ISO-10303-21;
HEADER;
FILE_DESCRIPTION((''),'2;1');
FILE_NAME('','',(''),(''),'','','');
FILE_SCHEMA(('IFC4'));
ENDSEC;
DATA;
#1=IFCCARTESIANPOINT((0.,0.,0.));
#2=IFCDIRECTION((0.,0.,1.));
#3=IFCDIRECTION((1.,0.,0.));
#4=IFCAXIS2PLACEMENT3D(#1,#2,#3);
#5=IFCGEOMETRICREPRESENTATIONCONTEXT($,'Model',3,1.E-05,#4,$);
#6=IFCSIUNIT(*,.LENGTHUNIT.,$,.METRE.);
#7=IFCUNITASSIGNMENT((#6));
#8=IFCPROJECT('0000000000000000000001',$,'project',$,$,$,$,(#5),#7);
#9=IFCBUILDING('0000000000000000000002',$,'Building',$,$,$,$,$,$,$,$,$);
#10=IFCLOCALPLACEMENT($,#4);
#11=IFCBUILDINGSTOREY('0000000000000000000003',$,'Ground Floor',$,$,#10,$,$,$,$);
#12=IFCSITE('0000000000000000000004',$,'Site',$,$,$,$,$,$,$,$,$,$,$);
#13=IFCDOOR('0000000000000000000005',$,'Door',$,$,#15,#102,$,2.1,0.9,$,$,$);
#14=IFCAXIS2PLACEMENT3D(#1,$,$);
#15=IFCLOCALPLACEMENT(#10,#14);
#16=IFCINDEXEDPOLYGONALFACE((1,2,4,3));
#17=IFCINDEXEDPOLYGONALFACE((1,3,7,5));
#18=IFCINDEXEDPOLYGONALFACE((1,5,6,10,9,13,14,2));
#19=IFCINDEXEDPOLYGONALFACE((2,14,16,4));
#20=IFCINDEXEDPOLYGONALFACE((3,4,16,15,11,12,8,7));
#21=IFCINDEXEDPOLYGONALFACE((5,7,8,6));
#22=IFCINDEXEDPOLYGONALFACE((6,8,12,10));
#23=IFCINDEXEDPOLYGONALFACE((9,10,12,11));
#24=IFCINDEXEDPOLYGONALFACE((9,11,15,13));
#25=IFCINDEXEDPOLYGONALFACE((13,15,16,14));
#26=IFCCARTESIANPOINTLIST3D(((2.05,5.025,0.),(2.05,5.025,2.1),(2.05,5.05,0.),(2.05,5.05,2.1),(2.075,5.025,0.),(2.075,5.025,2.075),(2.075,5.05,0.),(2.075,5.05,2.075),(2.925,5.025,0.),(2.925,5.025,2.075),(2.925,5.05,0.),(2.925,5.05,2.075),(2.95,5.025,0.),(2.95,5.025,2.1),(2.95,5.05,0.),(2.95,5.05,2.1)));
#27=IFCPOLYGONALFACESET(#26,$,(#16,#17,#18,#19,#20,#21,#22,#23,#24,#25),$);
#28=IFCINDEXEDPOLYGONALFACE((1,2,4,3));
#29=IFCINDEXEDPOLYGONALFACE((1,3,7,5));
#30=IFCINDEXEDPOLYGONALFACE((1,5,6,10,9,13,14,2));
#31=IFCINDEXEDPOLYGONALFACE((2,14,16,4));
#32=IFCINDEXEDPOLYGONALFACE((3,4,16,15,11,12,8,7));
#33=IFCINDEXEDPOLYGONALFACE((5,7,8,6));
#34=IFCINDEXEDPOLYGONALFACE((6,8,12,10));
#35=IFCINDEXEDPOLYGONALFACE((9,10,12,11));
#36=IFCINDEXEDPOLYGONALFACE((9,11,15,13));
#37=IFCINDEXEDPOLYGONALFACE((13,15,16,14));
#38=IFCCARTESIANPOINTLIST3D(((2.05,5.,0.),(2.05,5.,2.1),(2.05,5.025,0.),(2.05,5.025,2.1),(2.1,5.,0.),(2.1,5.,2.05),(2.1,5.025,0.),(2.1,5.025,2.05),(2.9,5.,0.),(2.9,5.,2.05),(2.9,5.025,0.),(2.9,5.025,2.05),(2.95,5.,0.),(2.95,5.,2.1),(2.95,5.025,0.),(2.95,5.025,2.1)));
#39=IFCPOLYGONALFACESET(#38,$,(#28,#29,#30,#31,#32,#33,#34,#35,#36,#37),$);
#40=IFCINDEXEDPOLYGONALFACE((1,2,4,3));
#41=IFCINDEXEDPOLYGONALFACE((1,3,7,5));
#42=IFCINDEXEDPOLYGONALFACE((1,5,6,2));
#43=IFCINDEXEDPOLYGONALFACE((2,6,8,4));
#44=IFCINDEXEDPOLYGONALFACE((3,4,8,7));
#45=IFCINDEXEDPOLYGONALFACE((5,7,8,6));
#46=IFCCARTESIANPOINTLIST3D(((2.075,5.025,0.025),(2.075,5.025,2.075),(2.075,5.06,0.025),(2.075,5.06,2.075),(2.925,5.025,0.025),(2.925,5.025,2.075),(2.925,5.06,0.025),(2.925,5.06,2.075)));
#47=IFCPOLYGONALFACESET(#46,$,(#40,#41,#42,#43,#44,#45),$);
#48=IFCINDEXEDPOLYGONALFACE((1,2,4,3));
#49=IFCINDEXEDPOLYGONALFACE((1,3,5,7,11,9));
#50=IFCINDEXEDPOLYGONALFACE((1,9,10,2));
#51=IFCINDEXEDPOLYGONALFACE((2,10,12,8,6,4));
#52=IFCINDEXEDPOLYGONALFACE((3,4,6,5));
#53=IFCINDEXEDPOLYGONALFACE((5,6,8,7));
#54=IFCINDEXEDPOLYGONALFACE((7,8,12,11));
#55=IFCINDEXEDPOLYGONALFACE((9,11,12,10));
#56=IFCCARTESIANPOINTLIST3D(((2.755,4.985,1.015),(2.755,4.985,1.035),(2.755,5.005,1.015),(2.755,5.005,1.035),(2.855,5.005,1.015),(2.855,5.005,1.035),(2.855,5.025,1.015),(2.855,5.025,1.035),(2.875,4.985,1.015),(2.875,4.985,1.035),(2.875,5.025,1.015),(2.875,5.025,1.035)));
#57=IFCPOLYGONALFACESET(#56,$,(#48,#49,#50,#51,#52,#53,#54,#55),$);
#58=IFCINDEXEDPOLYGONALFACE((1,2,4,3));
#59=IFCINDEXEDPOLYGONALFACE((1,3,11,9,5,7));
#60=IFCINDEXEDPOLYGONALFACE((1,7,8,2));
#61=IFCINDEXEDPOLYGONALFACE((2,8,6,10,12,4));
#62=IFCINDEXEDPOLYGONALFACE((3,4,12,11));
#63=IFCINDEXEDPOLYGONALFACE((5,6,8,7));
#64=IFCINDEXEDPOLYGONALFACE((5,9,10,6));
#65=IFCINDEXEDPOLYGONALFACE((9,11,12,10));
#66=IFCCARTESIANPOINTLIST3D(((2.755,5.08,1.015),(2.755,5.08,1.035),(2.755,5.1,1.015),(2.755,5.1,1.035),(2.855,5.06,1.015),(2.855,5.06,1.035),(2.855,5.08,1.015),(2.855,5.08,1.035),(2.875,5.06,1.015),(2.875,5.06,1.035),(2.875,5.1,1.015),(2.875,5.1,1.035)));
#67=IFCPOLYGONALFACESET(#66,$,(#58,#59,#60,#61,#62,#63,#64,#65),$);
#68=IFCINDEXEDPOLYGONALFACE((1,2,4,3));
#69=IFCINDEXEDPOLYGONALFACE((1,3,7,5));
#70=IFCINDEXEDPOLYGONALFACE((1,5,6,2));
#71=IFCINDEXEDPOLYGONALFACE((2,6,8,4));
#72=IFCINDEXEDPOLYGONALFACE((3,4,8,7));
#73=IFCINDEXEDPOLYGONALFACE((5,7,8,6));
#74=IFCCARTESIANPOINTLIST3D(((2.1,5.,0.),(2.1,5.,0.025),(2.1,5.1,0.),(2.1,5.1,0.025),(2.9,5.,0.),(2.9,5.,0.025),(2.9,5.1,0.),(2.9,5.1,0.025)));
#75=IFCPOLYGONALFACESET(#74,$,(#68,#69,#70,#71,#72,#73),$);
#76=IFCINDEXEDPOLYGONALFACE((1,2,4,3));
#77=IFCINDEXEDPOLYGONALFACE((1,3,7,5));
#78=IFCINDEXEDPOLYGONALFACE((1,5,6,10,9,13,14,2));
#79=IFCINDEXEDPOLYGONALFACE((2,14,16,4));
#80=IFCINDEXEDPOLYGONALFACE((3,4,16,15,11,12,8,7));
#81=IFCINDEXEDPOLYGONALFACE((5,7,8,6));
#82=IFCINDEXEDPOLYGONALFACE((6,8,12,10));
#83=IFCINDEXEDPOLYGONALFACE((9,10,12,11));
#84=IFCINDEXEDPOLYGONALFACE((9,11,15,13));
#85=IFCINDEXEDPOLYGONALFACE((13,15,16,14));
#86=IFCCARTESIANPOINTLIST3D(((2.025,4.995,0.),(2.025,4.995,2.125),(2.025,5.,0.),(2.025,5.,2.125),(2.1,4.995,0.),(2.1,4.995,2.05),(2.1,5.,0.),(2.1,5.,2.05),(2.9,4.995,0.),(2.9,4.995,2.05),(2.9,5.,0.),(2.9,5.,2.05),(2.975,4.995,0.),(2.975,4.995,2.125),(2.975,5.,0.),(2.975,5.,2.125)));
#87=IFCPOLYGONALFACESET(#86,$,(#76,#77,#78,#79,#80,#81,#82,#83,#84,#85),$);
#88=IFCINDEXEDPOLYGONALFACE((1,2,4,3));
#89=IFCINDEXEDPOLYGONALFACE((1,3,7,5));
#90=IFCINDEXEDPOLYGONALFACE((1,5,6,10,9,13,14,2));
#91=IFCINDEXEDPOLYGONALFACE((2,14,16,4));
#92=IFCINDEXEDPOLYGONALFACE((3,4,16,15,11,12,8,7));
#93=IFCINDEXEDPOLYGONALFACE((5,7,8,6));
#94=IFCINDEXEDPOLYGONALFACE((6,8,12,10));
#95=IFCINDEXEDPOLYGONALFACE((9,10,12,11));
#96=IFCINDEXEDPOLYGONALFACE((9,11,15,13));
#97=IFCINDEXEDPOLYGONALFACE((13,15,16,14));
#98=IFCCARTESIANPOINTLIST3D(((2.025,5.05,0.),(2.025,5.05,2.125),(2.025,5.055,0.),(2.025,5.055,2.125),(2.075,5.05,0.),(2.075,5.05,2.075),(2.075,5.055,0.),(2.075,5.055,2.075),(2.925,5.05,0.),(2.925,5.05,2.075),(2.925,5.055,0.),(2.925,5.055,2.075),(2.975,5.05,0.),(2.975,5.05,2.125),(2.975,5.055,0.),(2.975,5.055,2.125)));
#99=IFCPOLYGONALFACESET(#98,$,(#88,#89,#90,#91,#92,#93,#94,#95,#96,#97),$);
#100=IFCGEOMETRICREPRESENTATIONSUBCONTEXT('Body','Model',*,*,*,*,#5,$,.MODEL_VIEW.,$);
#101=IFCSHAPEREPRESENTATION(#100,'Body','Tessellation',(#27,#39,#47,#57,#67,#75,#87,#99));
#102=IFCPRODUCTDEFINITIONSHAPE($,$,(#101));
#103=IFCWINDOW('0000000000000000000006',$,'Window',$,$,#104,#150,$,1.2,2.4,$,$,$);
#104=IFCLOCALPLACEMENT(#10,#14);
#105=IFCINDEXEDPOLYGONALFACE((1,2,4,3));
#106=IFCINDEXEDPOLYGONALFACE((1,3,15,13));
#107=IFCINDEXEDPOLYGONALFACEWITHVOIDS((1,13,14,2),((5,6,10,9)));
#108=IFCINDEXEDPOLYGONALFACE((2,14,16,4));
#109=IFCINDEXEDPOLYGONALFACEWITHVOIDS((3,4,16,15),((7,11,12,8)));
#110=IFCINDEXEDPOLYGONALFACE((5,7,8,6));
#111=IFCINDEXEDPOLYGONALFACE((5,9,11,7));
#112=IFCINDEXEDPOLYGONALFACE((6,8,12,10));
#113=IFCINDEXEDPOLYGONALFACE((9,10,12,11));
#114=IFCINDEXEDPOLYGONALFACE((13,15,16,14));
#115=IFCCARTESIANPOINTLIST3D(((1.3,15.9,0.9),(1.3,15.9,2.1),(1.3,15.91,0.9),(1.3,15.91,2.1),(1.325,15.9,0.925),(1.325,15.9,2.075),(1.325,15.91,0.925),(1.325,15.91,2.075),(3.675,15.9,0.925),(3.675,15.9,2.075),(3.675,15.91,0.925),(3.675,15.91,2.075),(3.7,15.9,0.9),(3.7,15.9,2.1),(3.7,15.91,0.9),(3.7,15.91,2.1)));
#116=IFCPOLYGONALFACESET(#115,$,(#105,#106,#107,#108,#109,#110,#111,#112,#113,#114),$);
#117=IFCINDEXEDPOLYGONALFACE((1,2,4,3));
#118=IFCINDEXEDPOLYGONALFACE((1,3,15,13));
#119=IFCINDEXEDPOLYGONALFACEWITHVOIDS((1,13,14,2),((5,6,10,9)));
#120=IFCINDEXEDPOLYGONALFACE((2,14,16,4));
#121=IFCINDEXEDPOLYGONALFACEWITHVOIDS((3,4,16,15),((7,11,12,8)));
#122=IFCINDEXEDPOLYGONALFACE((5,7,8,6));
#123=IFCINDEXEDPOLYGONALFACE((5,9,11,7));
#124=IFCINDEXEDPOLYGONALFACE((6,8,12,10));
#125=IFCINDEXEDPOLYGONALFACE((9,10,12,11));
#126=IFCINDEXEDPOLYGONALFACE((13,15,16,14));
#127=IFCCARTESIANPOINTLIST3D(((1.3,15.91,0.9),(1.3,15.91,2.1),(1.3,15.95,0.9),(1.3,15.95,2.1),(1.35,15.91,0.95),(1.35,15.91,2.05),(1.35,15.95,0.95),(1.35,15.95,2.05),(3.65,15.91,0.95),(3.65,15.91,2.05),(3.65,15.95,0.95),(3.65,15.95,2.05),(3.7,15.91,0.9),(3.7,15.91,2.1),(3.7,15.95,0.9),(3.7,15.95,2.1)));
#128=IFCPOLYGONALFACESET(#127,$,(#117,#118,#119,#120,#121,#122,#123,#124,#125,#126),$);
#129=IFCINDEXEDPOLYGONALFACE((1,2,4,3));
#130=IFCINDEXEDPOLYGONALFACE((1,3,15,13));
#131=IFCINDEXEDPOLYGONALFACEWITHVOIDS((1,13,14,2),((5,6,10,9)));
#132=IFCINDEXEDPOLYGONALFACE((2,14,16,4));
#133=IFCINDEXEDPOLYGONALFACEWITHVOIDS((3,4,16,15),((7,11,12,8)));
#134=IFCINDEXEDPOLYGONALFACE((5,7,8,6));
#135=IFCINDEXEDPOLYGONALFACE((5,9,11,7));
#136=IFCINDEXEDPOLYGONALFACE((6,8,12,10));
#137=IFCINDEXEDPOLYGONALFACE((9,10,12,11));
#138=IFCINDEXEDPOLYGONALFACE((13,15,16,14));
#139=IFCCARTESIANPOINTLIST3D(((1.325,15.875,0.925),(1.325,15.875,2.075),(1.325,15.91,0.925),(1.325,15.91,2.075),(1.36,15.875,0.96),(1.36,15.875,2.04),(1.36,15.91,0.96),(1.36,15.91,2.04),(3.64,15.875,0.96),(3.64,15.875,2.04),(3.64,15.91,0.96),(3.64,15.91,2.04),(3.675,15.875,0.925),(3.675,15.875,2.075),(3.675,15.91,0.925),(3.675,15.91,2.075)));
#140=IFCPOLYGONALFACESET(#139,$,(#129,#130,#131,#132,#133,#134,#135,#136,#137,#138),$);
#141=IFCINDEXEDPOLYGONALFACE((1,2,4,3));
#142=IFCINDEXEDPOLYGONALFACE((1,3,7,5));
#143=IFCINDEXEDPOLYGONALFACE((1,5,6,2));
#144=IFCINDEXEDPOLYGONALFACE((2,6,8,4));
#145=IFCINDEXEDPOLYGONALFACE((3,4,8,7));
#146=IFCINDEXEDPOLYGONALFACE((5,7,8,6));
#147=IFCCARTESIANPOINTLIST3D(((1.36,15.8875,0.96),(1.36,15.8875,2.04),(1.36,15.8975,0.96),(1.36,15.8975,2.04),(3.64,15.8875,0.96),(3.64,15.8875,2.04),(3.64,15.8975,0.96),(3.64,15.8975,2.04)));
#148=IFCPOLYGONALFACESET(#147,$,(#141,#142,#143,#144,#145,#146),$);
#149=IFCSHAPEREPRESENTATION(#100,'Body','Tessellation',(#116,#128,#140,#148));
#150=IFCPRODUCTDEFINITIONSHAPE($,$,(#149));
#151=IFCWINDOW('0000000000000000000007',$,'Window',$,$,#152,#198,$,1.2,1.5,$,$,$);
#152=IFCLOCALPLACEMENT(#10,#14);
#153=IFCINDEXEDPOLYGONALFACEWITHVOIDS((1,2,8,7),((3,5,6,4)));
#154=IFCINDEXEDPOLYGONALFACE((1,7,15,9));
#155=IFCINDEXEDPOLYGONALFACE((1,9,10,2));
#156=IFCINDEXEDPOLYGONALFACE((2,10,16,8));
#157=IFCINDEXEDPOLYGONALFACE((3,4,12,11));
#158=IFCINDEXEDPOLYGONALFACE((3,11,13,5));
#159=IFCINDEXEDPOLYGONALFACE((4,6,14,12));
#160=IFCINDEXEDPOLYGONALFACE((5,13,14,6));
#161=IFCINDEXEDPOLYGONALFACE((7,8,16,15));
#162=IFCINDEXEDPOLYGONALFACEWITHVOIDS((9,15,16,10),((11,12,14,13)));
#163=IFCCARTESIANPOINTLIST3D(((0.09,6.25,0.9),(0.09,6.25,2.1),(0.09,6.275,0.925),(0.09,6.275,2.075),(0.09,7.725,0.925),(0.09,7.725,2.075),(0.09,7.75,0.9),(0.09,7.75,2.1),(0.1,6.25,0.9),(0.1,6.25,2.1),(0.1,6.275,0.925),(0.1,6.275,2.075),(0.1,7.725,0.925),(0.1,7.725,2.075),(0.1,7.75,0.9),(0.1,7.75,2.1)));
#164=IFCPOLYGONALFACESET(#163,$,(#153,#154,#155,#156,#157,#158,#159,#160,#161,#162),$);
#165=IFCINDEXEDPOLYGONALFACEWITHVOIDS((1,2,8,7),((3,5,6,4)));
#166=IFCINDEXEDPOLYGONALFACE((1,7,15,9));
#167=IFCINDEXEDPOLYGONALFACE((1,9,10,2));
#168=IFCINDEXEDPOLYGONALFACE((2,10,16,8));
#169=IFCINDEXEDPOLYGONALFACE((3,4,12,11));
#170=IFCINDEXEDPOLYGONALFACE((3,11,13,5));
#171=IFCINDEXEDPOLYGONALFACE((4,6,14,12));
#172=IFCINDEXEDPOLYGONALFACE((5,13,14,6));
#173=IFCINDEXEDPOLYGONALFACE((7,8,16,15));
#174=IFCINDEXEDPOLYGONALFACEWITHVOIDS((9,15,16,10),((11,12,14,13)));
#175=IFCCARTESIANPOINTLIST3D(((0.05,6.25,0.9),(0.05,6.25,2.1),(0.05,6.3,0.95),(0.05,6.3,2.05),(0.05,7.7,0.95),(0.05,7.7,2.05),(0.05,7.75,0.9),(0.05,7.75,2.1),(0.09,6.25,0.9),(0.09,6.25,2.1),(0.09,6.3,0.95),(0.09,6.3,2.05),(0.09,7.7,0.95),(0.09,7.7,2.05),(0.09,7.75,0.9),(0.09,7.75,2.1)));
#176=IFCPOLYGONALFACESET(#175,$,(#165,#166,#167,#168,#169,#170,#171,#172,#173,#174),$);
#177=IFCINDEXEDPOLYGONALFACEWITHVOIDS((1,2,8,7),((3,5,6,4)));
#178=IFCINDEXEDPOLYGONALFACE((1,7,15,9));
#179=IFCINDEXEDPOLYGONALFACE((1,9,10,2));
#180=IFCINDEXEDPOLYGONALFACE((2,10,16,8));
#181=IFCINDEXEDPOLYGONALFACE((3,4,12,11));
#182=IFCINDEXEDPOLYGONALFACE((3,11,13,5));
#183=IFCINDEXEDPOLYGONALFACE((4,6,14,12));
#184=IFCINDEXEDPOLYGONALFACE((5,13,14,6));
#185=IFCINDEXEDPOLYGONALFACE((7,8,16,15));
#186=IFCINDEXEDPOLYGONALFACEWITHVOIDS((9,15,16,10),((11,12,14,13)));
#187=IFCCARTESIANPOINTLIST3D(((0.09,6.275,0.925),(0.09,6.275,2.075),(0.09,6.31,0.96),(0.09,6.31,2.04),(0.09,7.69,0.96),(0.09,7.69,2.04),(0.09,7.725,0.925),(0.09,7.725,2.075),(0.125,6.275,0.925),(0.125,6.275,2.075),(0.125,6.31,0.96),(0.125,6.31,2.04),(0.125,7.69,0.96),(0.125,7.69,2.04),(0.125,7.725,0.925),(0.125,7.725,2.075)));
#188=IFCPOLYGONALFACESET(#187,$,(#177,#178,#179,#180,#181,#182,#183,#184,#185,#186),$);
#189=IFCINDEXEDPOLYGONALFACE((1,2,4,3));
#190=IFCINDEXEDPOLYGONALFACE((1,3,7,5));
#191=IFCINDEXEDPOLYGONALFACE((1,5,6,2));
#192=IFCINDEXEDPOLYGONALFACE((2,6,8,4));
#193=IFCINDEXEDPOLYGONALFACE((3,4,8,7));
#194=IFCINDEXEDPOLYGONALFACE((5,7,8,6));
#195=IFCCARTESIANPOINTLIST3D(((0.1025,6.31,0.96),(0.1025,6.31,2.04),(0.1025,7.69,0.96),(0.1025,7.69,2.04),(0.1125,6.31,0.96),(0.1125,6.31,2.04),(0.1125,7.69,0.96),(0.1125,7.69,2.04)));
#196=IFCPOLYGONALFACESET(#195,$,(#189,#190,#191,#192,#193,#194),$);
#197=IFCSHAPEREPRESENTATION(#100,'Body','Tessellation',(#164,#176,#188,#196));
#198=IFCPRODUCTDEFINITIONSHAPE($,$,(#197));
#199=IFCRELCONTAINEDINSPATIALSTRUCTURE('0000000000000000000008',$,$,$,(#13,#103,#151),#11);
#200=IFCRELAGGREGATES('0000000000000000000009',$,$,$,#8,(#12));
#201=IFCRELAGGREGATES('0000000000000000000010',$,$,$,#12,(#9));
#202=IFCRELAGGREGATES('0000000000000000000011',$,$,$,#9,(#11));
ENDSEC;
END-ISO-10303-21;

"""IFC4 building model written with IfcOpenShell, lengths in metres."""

from ifc_helpers import new_model, si_unit, frame, origin_with_axes, place, context, subcontext, project, spatial, line, indexed_curve, outline, extrude, element, save


model = new_model("IFC4")

# Units and contexts
model_context = context("Model", 3, precision=1e-05, world=origin_with_axes())
body_context = subcontext(model_context, "Body", "Model", "MODEL_VIEW")
ifc_project = project(units=[si_unit("LENGTHUNIT", "METRE")], contexts=[model_context])

# Site, building, storey
site = spatial("IfcSite", under=ifc_project, Name="Site")
building = spatial("IfcBuilding", under=site, Name="Building")
storey_placement = place(None, origin_with_axes())
storey = spatial("IfcBuildingStorey", under=building, at=storey_placement, Name="Ground Floor")

# Door
door_1_placement = place(storey_placement, frame((2.05, 5.0, 0.0), z_axis=(0.0, 0.0, 1.0), x_axis=(1.0, 0.0, 0.0)))
element("IfcDoor", 1, at=door_1_placement, inside=storey, Name="Door", OverallHeight=2.1, OverallWidth=0.9, context=body_context, shape_type="SweptSolid", body=[
    extrude(outline(indexed_curve([(0.0, 0.0), (0.0, 2.1), (0.9, 2.1), (0.9, 0.0), (0.875, 0.0), (0.875, 2.075), (0.025, 2.075), (0.025, 0.0)], segments=[line(1, 2, 3, 4, 5, 6, 7, 8, 1)])), frame((0.0, 0.025, 0.0), z_axis=(0.0, -1.0, 0.0), x_axis=(1.0, 0.0, 0.0)), (0.0, 0.0, -1.0), 0.025),
    extrude(outline(indexed_curve([(0.0, 0.0), (0.0, 2.1), (0.9, 2.1), (0.9, 0.0), (0.85, 0.0), (0.85, 2.05), (0.05, 2.05), (0.05, 0.0)], segments=[line(1, 2, 3, 4, 5, 6, 7, 8, 1)])), frame((0.0, 0.0, 0.0), z_axis=(0.0, -1.0, 0.0), x_axis=(1.0, 0.0, 0.0)), (0.0, 0.0, -1.0), 0.025),
    extrude(outline(indexed_curve([(0.0, 0.0), (0.85, 0.0), (0.85, 0.035), (0.0, 0.035)], segments=[line(1, 2, 3, 4, 1)])), frame((0.025, 0.025, 0.025), z_axis=(0.0, 0.0, 1.0), x_axis=(1.0, 0.0, 0.0)), (0.0, 0.0, 1.0), 2.05),
    extrude(outline(indexed_curve([(0.0, 0.0), (0.0, -0.04), (-0.12, -0.04), (-0.12, -0.02), (-0.02, -0.02), (-0.02, 0.0)], segments=[line(1, 2, 3, 4, 5, 6, 1)])), frame((0.825, 0.025, 1.015), z_axis=(0.0, 0.0, 1.0), x_axis=(1.0, 0.0, 0.0)), (0.0, 0.0, 1.0), 0.02),
    extrude(outline(indexed_curve([(0.0, 0.0), (0.0, 0.04), (-0.12, 0.04), (-0.12, 0.02), (-0.02, 0.02), (-0.02, 0.0)], segments=[line(1, 2, 3, 4, 5, 6, 1)])), frame((0.825, 0.06, 1.015), z_axis=(0.0, 0.0, 1.0), x_axis=(1.0, 0.0, 0.0)), (0.0, 0.0, 1.0), 0.02),
    extrude(outline(indexed_curve([(0.0, 0.0), (0.8, 0.0), (0.8, 0.1), (0.0, 0.1)], segments=[line(1, 2, 3, 4, 1)])), frame((0.05, 0.0, 0.0), z_axis=(0.0, 0.0, 1.0), x_axis=(1.0, 0.0, 0.0)), (0.0, 0.0, 1.0), 0.025),
    extrude(outline(indexed_curve([(0.0, 0.0), (0.0, 2.125), (0.95, 2.125), (0.95, 0.0), (0.875, 0.0), (0.875, 2.05), (0.075, 2.05), (0.075, 0.0)], segments=[line(1, 2, 3, 4, 5, 6, 7, 8, 1)])), frame((-0.025, -0.005, 0.0), z_axis=(0.0, -1.0, 0.0), x_axis=(1.0, 0.0, 0.0)), (0.0, 0.0, -1.0), 0.005),
    extrude(outline(indexed_curve([(0.0, 0.0), (0.0, 2.125), (0.95, 2.125), (0.95, 0.0), (0.9, 0.0), (0.9, 2.075), (0.05, 2.075), (0.05, 0.0)], segments=[line(1, 2, 3, 4, 5, 6, 7, 8, 1)])), frame((-0.025, 0.05, 0.0), z_axis=(0.0, -1.0, 0.0), x_axis=(1.0, 0.0, 0.0)), (0.0, 0.0, -1.0), 0.005),
])

# Windows
window_placement = place(storey_placement, frame((3.7, 16.0, 0.9), z_axis=(0.0, 0.0, 1.0), x_axis=(-1.0, 0.0, 0.0)))
element("IfcWindow", 2, at=window_placement, inside=storey, Name="Window", OverallHeight=1.2, OverallWidth=2.4, context=body_context, shape_type="SweptSolid", body=[
    extrude(outline(indexed_curve([(0.0, 0.0), (2.4, 0.0), (2.4, 1.2), (0.0, 1.2)], segments=[line(1, 2, 3, 4, 1)]), holes=[indexed_curve([(0.025, 0.025), (2.375, 0.025), (2.375, 1.175), (0.025, 1.175)], segments=[line(1, 2, 3, 4, 1)])]), frame((0.0, 0.09, 0.0), z_axis=(0.0, -1.0, 0.0), x_axis=(1.0, 0.0, 0.0)), (0.0, 0.0, -1.0), 0.01),
    extrude(outline(indexed_curve([(0.0, 0.0), (2.4, 0.0), (2.4, 1.2), (0.0, 1.2)], segments=[line(1, 2, 3, 4, 1)]), holes=[indexed_curve([(0.05, 0.05), (2.35, 0.05), (2.35, 1.15), (0.05, 1.15)], segments=[line(1, 2, 3, 4, 1)])]), frame((0.0, 0.05, 0.0), z_axis=(0.0, -1.0, 0.0), x_axis=(1.0, 0.0, 0.0)), (0.0, 0.0, -1.0), 0.04),
    extrude(outline(indexed_curve([(0.0, 0.0), (2.35, 0.0), (2.35, 1.15), (0.0, 1.15)], segments=[line(1, 2, 3, 4, 1)]), holes=[indexed_curve([(0.035, 0.035), (2.315, 0.035), (2.315, 1.115), (0.035, 1.115)], segments=[line(1, 2, 3, 4, 1)])]), frame((0.025, 0.09, 0.025), z_axis=(0.0, -1.0, 0.0), x_axis=(1.0, 0.0, 0.0)), (0.0, 0.0, -1.0), 0.035),
    extrude(outline(indexed_curve([(0.035, 0.035), (2.315, 0.035), (2.315, 1.115), (0.035, 1.115)], segments=[line(1, 2, 3, 4, 1)])), frame((0.025, 0.1025, 0.025), z_axis=(0.0, -1.0, 0.0), x_axis=(1.0, 0.0, 0.0)), (0.0, 0.0, -1.0), 0.01),
])
for number, where, z_axis, x_axis, name in (
    (3, (0.0, 7.75, 0.9), (0.0, 0.0, 1.0), (0.0, -1.0, 0.0), "Window"),
):
    element("IfcWindow", number, at=place(storey_placement, frame(where, z_axis=z_axis, x_axis=x_axis)), inside=storey, Name=name, OverallHeight=1.2, OverallWidth=1.5, context=body_context, shape_type="SweptSolid", body=[
        extrude(outline(indexed_curve([(0.0, 0.0), (1.5, 0.0), (1.5, 1.2), (0.0, 1.2)], segments=[line(1, 2, 3, 4, 1)]), holes=[indexed_curve([(0.025, 0.025), (1.475, 0.025), (1.475, 1.175), (0.025, 1.175)], segments=[line(1, 2, 3, 4, 1)])]), frame((0.0, 0.09, 0.0), z_axis=(0.0, -1.0, 0.0), x_axis=(1.0, 0.0, 0.0)), (0.0, 0.0, -1.0), 0.01),
        extrude(outline(indexed_curve([(0.0, 0.0), (1.5, 0.0), (1.5, 1.2), (0.0, 1.2)], segments=[line(1, 2, 3, 4, 1)]), holes=[indexed_curve([(0.05, 0.05), (1.45, 0.05), (1.45, 1.15), (0.05, 1.15)], segments=[line(1, 2, 3, 4, 1)])]), frame((0.0, 0.05, 0.0), z_axis=(0.0, -1.0, 0.0), x_axis=(1.0, 0.0, 0.0)), (0.0, 0.0, -1.0), 0.04),
        extrude(outline(indexed_curve([(0.0, 0.0), (1.45, 0.0), (1.45, 1.15), (0.0, 1.15)], segments=[line(1, 2, 3, 4, 1)]), holes=[indexed_curve([(0.035, 0.035), (1.415, 0.035), (1.415, 1.115), (0.035, 1.115)], segments=[line(1, 2, 3, 4, 1)])]), frame((0.025, 0.09, 0.025), z_axis=(0.0, -1.0, 0.0), x_axis=(1.0, 0.0, 0.0)), (0.0, 0.0, -1.0), 0.035),
        extrude(outline(indexed_curve([(0.035, 0.035), (1.415, 0.035), (1.415, 1.115), (0.035, 1.115)], segments=[line(1, 2, 3, 4, 1)])), frame((0.025, 0.1025, 0.025), z_axis=(0.0, -1.0, 0.0), x_axis=(1.0, 0.0, 0.0)), (0.0, 0.0, -1.0), 0.01),
    ])

save(model, "model.ifc")
